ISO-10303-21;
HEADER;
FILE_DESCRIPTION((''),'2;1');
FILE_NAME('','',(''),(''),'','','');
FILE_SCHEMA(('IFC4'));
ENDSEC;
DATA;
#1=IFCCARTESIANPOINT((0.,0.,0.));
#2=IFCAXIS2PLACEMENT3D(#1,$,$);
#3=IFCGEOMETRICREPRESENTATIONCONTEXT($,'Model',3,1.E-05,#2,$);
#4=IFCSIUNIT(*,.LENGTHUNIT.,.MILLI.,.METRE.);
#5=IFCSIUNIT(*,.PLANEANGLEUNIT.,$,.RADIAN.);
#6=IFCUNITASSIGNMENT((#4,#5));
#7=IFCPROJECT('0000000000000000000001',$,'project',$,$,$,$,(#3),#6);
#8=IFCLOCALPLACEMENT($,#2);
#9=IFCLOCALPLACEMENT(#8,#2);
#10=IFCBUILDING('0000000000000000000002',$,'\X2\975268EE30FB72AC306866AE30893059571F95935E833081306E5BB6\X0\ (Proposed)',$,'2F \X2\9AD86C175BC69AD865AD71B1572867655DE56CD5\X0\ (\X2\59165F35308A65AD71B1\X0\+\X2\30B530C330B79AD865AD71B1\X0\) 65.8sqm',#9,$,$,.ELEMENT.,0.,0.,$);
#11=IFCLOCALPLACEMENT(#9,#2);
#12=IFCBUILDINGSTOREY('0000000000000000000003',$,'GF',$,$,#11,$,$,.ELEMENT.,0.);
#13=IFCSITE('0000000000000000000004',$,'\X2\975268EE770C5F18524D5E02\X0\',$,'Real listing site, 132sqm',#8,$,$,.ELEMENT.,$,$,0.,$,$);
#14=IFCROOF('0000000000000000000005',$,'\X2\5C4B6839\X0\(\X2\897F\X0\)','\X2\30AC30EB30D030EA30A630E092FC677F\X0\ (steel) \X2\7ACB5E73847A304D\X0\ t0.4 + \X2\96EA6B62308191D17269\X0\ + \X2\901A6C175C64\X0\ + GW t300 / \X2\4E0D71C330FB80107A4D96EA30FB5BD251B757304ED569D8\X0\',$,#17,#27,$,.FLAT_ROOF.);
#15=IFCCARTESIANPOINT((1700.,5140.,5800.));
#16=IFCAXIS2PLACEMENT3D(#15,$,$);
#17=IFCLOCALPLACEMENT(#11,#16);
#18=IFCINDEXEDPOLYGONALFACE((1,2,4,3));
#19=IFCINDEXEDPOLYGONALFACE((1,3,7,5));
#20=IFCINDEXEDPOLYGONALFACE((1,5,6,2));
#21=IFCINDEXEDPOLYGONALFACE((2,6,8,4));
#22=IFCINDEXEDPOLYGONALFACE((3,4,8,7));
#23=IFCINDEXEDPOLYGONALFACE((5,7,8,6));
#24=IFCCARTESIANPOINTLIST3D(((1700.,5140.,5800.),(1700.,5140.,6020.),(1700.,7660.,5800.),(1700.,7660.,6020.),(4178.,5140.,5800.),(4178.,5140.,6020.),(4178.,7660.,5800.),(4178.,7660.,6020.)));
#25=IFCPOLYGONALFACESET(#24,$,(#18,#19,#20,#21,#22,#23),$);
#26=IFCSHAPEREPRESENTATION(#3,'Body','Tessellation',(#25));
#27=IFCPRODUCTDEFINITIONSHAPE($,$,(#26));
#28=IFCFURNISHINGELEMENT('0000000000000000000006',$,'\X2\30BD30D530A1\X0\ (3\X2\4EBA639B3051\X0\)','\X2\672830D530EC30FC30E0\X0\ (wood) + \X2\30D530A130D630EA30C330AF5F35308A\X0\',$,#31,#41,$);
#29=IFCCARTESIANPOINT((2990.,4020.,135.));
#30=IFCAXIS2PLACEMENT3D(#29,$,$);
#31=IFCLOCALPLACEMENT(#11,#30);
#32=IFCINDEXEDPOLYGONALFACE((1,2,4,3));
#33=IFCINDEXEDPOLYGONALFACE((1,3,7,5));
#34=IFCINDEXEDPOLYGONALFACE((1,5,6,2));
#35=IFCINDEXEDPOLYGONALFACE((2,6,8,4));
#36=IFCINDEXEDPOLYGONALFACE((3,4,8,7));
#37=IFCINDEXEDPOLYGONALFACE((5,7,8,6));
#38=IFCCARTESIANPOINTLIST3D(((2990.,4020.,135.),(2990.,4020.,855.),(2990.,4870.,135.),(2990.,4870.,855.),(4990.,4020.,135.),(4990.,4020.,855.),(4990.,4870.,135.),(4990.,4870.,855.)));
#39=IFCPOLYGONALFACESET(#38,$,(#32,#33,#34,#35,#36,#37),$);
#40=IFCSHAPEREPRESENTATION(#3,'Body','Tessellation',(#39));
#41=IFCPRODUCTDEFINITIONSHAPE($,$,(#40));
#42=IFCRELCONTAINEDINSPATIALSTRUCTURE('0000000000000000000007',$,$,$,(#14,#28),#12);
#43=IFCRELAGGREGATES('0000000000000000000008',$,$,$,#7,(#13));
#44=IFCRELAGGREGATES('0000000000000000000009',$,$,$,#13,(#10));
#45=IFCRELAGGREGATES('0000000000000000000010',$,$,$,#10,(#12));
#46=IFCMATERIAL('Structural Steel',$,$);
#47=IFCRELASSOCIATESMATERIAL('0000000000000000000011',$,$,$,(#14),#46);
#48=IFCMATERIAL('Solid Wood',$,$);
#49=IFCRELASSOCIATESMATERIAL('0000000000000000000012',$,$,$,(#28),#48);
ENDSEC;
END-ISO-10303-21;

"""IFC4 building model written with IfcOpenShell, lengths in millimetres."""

from ifc_helpers import new_model, si_unit, frame, frame_2d, origin, place, context, project, spatial, rectangle, extrude, material, element, save


model = new_model("IFC4")

# Units and contexts
model_context = context("Model", 3, precision=1e-05, world=origin())
ifc_project = project(units=[si_unit("LENGTHUNIT", "METRE", prefix="MILLI"), si_unit("PLANEANGLEUNIT", "RADIAN")], contexts=[model_context])

# Site, building, storey
site_placement = place(None, origin())
site = spatial("IfcSite", under=ifc_project, at=site_placement, Name="青森県弘前市", ObjectType="Real listing site, 132sqm", CompositionType="ELEMENT", RefElevation=0.0)
building_placement = place(site_placement, origin())
building = spatial("IfcBuilding", under=site, at=building_placement, Name="青森・犬と暮らす土間広めの家 (Proposed)", ObjectType="2F 高気密高断熱在来工法 (外張り断熱+サッシ高断熱) 65.8sqm", CompositionType="ELEMENT", ElevationOfRefHeight=0.0, ElevationOfTerrain=0.0)
storey_placement = place(building_placement, origin())
storey = spatial("IfcBuildingStorey", under=building, at=storey_placement, Name="GF", CompositionType="ELEMENT", Elevation=0.0)

# Shared definitions
ifc_material_1 = material(Name="Solid Wood")

# Roof
ifc_material_2 = material(Name="Structural Steel")
for number, where, name in (
    (1, (1700.0, 5140.0, 5800.0), "屋根(西)"),
):
    element("IfcRoof", number, at=place(storey_placement, frame(where)), inside=storey, material=ifc_material_2, Name=name, Description="ガルバリウム鋼板 (steel) 立平葺き t0.4 + 雪止め金物 + 通気層 + GW t300 / 不燃・耐積雪・寒冷地仕様", PredefinedType="FLAT_ROOF", context=model_context, shape_type="SweptSolid", body=[
        extrude(rectangle(XDim=2478.0, YDim=2520.0, at=frame_2d((1239.0, 1260.0))), frame((1700.0, 5140.0, 5800.0)), (0.0, 0.0, 1.0), 220.0),
    ])

# Furnishing element
furnishing_placement = place(storey_placement, frame((2990.0, 4020.0, 135.0)))
element("IfcFurnishingElement", 2, at=furnishing_placement, inside=storey, material=ifc_material_1, Name="ソファ (3人掛け)", Description="木フレーム (wood) + ファブリック張り", context=model_context, shape_type="SweptSolid", body=[
    extrude(rectangle(XDim=2000.0, YDim=850.0, at=frame_2d((1000.0, 425.0))), frame((2990.0, 4020.0, 135.0)), (0.0, 0.0, 1.0), 720.0),
])

save(model, "model.ifc")
